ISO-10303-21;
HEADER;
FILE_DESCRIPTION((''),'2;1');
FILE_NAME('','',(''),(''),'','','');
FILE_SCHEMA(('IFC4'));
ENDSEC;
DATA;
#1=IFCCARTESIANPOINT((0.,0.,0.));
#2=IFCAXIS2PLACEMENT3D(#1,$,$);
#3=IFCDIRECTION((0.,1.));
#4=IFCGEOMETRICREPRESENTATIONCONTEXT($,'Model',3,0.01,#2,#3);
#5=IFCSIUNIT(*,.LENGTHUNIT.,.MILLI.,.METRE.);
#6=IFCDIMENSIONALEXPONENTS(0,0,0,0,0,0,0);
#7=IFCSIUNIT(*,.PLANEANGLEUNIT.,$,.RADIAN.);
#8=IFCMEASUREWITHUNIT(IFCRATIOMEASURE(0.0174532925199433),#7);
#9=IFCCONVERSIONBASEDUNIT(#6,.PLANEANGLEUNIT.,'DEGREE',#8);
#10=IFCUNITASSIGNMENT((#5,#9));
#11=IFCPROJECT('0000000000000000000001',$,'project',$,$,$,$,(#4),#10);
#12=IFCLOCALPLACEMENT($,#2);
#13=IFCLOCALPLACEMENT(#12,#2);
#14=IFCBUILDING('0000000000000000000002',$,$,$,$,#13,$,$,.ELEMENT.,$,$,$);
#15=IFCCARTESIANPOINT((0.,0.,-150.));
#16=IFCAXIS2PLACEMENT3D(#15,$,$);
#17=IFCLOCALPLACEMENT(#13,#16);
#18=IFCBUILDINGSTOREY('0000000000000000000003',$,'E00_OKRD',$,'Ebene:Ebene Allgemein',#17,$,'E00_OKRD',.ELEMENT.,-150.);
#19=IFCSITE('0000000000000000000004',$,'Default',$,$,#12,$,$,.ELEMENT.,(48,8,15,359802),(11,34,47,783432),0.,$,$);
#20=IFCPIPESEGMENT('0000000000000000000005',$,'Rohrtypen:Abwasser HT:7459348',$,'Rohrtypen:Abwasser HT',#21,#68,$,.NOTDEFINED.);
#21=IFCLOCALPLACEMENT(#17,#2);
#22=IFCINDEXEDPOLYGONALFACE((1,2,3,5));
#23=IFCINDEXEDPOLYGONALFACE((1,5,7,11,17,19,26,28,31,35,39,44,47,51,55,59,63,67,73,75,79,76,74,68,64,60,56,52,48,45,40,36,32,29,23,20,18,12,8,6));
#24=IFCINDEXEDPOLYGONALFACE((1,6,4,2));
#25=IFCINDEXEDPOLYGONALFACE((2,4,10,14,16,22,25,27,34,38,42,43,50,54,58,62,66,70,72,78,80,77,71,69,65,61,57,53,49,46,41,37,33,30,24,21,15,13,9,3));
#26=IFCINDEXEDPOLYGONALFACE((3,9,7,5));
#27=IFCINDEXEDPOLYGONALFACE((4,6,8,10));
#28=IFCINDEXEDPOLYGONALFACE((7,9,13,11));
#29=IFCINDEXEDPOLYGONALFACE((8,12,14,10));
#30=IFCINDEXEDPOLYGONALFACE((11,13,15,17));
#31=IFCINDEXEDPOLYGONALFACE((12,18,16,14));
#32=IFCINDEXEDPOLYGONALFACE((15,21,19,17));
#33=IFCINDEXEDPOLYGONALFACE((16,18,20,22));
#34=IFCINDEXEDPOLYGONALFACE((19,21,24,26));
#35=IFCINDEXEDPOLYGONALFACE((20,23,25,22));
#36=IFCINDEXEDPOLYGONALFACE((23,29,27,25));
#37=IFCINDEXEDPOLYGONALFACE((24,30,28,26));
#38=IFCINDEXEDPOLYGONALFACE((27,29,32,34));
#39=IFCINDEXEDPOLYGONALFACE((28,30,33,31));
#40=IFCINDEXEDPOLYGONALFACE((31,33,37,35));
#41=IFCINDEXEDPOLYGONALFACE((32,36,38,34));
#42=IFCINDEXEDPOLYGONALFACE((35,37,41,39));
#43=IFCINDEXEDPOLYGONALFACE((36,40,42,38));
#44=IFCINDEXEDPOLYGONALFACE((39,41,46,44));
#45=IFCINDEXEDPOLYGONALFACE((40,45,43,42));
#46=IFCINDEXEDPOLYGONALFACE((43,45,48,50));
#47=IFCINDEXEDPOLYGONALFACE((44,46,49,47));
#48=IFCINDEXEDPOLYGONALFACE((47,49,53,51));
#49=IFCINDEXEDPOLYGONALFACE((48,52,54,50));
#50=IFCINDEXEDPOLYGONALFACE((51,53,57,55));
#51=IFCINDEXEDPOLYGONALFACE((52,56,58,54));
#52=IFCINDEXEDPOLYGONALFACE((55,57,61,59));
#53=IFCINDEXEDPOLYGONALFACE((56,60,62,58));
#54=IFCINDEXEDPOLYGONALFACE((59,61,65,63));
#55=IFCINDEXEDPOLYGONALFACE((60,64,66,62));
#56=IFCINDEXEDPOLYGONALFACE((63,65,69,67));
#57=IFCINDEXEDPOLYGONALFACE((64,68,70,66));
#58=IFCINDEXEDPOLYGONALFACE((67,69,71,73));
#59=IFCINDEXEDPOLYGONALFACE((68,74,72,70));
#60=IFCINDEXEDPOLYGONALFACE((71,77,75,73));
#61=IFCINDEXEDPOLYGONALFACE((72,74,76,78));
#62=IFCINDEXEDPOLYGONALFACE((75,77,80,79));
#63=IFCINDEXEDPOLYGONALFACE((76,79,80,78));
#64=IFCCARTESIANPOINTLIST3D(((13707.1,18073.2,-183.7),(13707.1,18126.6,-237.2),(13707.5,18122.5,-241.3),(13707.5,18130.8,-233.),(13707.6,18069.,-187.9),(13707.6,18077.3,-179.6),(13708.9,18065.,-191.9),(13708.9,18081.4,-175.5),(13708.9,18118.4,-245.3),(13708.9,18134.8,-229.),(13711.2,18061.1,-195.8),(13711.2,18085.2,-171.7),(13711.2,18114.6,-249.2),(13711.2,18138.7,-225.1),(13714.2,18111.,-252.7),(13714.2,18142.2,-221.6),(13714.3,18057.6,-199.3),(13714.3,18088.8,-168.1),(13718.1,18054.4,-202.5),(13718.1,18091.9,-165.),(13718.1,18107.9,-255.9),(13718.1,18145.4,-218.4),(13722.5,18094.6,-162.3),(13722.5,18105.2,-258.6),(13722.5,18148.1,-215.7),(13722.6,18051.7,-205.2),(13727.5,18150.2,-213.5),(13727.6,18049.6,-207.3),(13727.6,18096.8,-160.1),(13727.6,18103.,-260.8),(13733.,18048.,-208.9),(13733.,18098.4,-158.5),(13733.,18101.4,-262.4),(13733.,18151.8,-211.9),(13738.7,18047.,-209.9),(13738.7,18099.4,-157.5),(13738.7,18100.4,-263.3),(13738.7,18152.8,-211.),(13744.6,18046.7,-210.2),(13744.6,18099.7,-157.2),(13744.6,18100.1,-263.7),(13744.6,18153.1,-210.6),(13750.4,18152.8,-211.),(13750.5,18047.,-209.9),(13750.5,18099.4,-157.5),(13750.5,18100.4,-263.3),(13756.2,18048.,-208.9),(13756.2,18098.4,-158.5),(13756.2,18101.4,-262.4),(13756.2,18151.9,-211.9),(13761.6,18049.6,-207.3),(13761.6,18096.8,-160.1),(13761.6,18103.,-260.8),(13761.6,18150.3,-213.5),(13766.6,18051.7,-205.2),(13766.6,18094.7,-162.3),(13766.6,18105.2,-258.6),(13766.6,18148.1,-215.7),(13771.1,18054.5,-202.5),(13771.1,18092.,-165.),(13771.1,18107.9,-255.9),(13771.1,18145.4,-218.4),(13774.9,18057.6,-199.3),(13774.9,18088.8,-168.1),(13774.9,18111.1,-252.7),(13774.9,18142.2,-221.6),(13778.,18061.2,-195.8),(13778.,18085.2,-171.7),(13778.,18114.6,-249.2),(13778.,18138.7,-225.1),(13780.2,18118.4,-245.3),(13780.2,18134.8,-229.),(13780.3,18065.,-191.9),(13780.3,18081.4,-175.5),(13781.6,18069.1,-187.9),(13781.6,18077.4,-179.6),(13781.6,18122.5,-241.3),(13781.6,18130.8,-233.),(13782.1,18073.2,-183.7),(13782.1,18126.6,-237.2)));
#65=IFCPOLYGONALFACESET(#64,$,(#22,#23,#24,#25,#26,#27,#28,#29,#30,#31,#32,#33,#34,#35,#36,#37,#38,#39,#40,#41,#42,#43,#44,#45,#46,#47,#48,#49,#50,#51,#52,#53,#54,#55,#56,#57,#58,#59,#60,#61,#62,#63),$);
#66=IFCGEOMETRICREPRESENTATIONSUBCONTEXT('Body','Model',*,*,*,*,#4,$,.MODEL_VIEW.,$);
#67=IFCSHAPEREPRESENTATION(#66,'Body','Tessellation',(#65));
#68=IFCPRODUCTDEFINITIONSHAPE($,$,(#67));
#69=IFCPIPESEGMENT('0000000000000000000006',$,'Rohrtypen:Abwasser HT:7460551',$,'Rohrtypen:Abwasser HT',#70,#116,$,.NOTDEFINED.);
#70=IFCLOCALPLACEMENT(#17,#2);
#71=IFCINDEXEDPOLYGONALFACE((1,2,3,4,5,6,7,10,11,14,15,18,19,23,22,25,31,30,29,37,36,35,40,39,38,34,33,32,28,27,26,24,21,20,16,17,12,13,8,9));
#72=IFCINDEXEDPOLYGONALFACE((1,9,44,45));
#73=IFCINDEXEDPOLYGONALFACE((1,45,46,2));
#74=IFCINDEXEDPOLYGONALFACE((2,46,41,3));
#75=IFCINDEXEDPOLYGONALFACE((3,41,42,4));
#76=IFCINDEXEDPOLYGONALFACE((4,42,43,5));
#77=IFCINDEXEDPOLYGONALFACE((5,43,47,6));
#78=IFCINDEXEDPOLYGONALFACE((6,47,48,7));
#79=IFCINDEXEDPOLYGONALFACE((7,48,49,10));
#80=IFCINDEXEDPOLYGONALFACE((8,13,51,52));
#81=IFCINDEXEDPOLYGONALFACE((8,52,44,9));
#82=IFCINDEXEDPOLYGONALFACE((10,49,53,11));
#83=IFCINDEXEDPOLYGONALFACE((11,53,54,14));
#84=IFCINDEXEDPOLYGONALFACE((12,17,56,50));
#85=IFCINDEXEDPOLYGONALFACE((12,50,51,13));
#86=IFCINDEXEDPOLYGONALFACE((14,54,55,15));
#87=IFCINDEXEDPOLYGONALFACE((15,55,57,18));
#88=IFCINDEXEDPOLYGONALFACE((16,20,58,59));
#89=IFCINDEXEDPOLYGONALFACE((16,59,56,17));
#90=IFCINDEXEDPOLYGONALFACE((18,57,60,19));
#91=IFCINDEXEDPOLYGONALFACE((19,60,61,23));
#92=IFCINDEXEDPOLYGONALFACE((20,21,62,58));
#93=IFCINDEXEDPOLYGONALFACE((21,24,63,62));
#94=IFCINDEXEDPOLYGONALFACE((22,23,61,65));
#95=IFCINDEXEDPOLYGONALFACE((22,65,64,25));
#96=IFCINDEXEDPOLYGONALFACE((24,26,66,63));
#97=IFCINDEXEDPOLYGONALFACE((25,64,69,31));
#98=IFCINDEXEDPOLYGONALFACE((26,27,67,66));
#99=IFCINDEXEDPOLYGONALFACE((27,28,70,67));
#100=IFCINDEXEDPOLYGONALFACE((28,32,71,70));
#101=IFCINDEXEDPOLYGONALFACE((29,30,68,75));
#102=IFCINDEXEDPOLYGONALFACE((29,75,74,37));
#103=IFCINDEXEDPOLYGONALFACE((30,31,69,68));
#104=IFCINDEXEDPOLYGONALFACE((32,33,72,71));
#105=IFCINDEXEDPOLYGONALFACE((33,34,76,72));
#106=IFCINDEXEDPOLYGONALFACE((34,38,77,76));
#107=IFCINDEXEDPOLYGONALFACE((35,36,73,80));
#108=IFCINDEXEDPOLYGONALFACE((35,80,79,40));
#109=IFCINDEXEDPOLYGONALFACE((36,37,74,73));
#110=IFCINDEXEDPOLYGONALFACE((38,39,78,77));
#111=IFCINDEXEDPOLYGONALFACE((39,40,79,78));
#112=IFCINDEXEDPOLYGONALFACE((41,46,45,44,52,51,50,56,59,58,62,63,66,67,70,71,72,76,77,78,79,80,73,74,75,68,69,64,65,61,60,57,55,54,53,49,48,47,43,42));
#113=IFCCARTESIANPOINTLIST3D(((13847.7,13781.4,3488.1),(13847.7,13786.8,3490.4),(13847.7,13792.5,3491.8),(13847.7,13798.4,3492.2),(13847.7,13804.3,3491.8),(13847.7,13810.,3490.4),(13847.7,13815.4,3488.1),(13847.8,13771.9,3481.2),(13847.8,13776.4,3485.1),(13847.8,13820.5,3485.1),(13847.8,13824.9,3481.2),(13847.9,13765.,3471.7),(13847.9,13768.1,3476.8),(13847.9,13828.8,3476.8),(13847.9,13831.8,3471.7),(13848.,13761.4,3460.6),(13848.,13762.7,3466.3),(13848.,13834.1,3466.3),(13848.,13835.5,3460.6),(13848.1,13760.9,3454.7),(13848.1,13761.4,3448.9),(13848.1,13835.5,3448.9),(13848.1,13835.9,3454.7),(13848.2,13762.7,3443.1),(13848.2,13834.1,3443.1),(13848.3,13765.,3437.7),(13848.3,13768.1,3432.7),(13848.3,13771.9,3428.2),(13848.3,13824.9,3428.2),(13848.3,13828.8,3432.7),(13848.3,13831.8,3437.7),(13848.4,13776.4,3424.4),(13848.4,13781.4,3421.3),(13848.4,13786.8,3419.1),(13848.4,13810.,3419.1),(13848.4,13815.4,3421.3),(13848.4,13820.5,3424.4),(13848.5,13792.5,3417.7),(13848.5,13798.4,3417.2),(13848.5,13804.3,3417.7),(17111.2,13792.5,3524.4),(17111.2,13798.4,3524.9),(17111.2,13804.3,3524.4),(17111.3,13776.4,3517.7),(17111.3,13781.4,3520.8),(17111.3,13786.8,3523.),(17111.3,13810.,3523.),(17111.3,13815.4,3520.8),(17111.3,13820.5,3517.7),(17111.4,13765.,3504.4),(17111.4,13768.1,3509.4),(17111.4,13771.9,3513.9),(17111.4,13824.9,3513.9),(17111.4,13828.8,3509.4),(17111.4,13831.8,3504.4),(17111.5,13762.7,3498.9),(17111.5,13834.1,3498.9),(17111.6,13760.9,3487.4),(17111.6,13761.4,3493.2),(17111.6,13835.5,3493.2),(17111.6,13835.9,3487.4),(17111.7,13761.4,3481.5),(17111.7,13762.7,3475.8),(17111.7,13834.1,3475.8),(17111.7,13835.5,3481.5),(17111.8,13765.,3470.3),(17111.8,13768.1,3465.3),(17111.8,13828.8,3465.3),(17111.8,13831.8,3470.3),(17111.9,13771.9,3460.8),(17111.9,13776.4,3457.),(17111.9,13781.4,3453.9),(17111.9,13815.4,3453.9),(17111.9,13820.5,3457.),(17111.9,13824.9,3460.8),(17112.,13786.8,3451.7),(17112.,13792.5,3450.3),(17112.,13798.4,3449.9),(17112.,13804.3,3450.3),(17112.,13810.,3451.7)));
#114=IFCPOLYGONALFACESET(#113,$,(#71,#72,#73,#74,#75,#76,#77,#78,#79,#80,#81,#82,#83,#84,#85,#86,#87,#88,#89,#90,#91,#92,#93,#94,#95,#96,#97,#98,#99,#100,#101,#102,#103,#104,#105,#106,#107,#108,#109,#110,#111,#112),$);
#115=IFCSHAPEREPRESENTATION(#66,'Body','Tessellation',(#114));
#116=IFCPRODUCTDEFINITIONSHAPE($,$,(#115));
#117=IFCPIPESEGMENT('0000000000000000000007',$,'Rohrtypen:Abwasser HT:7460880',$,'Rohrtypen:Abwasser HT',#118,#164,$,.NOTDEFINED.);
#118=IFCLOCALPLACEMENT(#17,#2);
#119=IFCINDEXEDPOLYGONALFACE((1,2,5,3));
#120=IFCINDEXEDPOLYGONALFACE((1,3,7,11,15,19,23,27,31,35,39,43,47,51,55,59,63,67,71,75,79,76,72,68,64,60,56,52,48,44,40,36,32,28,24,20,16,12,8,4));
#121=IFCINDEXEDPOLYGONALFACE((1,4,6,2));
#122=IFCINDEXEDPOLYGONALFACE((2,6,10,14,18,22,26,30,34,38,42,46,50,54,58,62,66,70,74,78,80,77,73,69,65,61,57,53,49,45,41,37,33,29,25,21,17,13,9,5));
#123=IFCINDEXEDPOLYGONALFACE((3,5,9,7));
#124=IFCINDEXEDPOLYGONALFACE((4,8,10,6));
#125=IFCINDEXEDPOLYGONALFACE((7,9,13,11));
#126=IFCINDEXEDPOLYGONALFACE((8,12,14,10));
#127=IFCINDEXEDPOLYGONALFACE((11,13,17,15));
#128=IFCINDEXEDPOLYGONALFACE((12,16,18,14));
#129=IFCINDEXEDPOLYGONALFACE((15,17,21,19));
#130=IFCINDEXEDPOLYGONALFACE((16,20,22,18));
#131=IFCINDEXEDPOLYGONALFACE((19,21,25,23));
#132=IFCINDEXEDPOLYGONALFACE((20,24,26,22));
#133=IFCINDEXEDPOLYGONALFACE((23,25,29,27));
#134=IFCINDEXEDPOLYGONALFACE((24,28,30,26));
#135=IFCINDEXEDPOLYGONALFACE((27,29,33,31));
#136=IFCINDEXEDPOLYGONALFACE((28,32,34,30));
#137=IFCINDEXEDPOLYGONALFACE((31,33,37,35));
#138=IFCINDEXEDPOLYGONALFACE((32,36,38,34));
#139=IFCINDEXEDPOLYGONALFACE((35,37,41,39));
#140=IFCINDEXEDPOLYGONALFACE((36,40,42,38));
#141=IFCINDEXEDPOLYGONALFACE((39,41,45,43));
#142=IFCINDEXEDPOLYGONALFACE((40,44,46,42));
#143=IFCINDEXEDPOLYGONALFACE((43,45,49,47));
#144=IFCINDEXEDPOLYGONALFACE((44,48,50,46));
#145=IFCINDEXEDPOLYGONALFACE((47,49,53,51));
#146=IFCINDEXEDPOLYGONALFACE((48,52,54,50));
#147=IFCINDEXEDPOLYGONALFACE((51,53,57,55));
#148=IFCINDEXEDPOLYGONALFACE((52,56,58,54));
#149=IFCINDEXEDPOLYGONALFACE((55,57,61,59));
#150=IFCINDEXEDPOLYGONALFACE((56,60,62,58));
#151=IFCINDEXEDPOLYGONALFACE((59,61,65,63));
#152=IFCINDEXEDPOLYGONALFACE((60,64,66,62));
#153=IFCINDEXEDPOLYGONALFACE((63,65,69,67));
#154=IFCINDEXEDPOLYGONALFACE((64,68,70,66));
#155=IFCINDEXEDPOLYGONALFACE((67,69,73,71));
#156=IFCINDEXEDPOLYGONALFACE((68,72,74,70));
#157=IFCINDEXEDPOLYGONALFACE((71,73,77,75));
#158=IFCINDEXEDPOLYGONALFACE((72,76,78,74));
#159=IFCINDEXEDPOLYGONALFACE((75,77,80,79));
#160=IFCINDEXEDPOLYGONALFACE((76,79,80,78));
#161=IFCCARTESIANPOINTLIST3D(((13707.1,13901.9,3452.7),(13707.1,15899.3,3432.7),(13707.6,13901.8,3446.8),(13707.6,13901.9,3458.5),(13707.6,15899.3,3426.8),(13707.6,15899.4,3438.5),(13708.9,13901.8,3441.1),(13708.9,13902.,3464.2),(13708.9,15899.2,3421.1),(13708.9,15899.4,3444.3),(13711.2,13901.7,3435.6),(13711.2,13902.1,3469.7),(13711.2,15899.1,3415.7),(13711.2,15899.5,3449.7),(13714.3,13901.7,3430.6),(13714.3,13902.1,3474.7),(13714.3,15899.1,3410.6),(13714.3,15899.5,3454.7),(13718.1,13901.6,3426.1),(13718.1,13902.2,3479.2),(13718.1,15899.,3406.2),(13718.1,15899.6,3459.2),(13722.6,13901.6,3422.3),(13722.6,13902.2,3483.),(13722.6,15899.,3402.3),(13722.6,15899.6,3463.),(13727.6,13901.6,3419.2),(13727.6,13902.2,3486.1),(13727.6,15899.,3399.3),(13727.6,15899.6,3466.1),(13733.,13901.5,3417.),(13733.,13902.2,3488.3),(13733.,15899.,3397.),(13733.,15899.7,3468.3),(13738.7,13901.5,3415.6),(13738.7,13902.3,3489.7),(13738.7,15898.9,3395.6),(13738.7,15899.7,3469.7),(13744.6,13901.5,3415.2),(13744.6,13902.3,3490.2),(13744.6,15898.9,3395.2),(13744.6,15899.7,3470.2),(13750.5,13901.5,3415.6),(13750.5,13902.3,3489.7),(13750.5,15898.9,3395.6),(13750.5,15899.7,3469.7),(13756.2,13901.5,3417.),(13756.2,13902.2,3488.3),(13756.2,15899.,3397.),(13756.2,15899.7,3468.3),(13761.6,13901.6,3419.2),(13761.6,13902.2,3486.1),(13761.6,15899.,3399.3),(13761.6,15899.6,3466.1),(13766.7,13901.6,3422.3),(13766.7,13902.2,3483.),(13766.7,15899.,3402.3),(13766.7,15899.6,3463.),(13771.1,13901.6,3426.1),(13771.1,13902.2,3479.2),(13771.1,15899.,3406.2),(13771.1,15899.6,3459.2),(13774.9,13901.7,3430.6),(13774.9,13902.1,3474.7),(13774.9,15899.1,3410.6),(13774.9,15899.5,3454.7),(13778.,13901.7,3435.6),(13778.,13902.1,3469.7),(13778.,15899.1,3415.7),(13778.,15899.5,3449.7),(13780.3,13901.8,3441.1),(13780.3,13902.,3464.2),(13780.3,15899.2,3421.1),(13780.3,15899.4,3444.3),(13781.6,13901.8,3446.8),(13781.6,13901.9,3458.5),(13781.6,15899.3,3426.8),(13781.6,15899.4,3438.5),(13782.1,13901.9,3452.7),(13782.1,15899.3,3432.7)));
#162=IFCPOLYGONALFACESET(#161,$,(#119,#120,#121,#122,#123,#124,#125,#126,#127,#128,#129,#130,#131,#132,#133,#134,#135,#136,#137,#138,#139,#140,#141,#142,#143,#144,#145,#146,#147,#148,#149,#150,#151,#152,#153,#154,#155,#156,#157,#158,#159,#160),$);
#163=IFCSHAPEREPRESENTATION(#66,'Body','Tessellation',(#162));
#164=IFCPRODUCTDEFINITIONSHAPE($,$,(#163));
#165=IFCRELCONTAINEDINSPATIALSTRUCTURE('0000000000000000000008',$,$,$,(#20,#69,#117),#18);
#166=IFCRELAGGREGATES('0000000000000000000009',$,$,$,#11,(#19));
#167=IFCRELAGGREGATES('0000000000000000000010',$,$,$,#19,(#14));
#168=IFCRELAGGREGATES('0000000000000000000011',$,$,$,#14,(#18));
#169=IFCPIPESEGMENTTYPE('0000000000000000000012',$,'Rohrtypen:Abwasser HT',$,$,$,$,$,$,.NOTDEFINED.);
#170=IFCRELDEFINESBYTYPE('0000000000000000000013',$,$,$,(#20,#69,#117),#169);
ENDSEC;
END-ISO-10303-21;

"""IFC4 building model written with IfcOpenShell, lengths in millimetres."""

from ifc_helpers import new_model, entity, si_unit, converted_unit, direction, frame, origin, place, context, subcontext, project, spatial, indexed_curve, outline, extrude, type_object, element, save


model = new_model("IFC4")

# Units and contexts
model_context = context("Model", 3, precision=0.01, world=origin(), true_north=direction((0.0, 1.0)))
body_context = subcontext(model_context, "Body", "Model", "MODEL_VIEW")
ifc_project = project(units=[si_unit("LENGTHUNIT", "METRE", prefix="MILLI"), converted_unit("PLANEANGLEUNIT", "DEGREE", entity("IfcRatioMeasure", 0.0174532925199433), si_unit("PLANEANGLEUNIT", "RADIAN"), dimensions=[0, 0, 0, 0, 0, 0, 0])], contexts=[model_context])

# Site, building, storey
site_placement = place(None, origin())
site = spatial("IfcSite", under=ifc_project, at=site_placement, Name="Default", CompositionType="ELEMENT", RefLatitude=(48, 8, 15, 359802), RefLongitude=(11, 34, 47, 783432), RefElevation=0.0)
building_placement = place(site_placement, origin())
building = spatial("IfcBuilding", under=site, at=building_placement, CompositionType="ELEMENT")
storey_placement = place(building_placement, frame((0.0, 0.0, -150.0)))
storey = spatial("IfcBuildingStorey", under=building, at=storey_placement, Name="E00_OKRD", ObjectType="Ebene:Ebene Allgemein", LongName="E00_OKRD", CompositionType="ELEMENT", Elevation=-150.0)

# Pipe segments
pipe_segment_type_1 = type_object("IfcPipeSegmentType", Name="Rohrtypen:Abwasser HT", PredefinedType="NOTDEFINED")
pipe_segment_1_placement = place(storey_placement, origin())
element("IfcPipeSegment", 1, at=pipe_segment_1_placement, inside=storey, type_object=pipe_segment_type_1, Name="Rohrtypen:Abwasser HT:7459348", ObjectType="Rohrtypen:Abwasser HT", PredefinedType="NOTDEFINED", context=body_context, shape_type="SweptSolid", body=[
    extrude(outline(indexed_curve([(37.5, 0.0), (37.0, 5.9), (35.7, 11.6), (33.4, 17.0), (30.3, 22.0), (26.5, 26.5), (22.0, 30.3), (17.0, 33.4), (11.6, 35.7), (5.9, 37.0), (0.0, 37.5), (-5.9, 37.0), (-11.6, 35.7), (-17.0, 33.4), (-22.0, 30.3), (-26.5, 26.5), (-30.3, 22.0), (-33.4, 17.0), (-35.7, 11.6), (-37.0, 5.9), (-37.5, 0.0), (-37.0, -5.9), (-35.7, -11.6), (-33.4, -17.0), (-30.3, -22.0), (-26.5, -26.5), (-22.0, -30.3), (-17.0, -33.4), (-11.6, -35.7), (-5.9, -37.0), (0.0, -37.5), (5.9, -37.0), (11.6, -35.7), (17.0, -33.4), (22.0, -30.3), (26.5, -26.5), (30.3, -22.0), (33.4, -17.0), (35.7, -11.6), (37.0, -5.9), (37.5, 0.0)], self_intersect=False)), frame((13744.6, 18126.6, -237.2), z_axis=(0.000263, -0.707107, 0.707107), x_axis=(1.0, 0.000372, 0.0)), (0.0, 0.0, 1.0), 75.6),
])
pipe_segment_2_placement = place(storey_placement, origin())
element("IfcPipeSegment", 2, at=pipe_segment_2_placement, inside=storey, type_object=pipe_segment_type_1, Name="Rohrtypen:Abwasser HT:7460551", ObjectType="Rohrtypen:Abwasser HT", PredefinedType="NOTDEFINED", context=body_context, shape_type="SweptSolid", body=[
    extrude(outline(indexed_curve([(37.5, 0.0), (37.0, 5.9), (35.7, 11.6), (33.4, 17.0), (30.3, 22.0), (26.5, 26.5), (22.0, 30.3), (17.0, 33.4), (11.6, 35.7), (5.9, 37.0), (0.0, 37.5), (-5.9, 37.0), (-11.6, 35.7), (-17.0, 33.4), (-22.0, 30.3), (-26.5, 26.5), (-30.3, 22.0), (-33.4, 17.0), (-35.7, 11.6), (-37.0, 5.9), (-37.5, 0.0), (-37.0, -5.9), (-35.7, -11.6), (-33.4, -17.0), (-30.3, -22.0), (-26.5, -26.5), (-22.0, -30.3), (-17.0, -33.4), (-11.6, -35.7), (-5.9, -37.0), (0.0, -37.5), (5.9, -37.0), (11.6, -35.7), (17.0, -33.4), (22.0, -30.3), (26.5, -26.5), (30.3, -22.0), (33.4, -17.0), (35.7, -11.6), (37.0, -5.9), (37.5, 0.0)], self_intersect=False)), frame((13848.1, 13798.4, 3454.7), z_axis=(0.99995, 0.0, 0.009997), x_axis=(0.0, -1.0, 0.0)), (0.0, 0.0, 1.0), 3263.7),
])
pipe_segment_3_placement = place(storey_placement, origin())
element("IfcPipeSegment", 3, at=pipe_segment_3_placement, inside=storey, type_object=pipe_segment_type_1, Name="Rohrtypen:Abwasser HT:7460880", ObjectType="Rohrtypen:Abwasser HT", PredefinedType="NOTDEFINED", context=body_context, shape_type="SweptSolid", body=[
    extrude(outline(indexed_curve([(37.5, 0.0), (37.0, 5.9), (35.7, 11.6), (33.4, 17.0), (30.3, 22.0), (26.5, 26.5), (22.0, 30.3), (17.0, 33.4), (11.6, 35.7), (5.9, 37.0), (0.0, 37.5), (-5.9, 37.0), (-11.6, 35.7), (-17.0, 33.4), (-22.0, 30.3), (-26.5, 26.5), (-30.3, 22.0), (-33.4, 17.0), (-35.7, 11.6), (-37.0, 5.9), (-37.5, 0.0), (-37.0, -5.9), (-35.7, -11.6), (-33.4, -17.0), (-30.3, -22.0), (-26.5, -26.5), (-22.0, -30.3), (-17.0, -33.4), (-11.6, -35.7), (-5.9, -37.0), (0.0, -37.5), (5.9, -37.0), (11.6, -35.7), (17.0, -33.4), (22.0, -30.3), (26.5, -26.5), (30.3, -22.0), (33.4, -17.0), (35.7, -11.6), (37.0, -5.9), (37.5, 0.0)], self_intersect=False)), frame((13744.6, 13901.9, 3452.7), z_axis=(0.0, 0.99995, -0.01), x_axis=(1.0, 0.0, 0.0)), (0.0, 0.0, 1.0), 1997.5),
])

save(model, "model.ifc")
